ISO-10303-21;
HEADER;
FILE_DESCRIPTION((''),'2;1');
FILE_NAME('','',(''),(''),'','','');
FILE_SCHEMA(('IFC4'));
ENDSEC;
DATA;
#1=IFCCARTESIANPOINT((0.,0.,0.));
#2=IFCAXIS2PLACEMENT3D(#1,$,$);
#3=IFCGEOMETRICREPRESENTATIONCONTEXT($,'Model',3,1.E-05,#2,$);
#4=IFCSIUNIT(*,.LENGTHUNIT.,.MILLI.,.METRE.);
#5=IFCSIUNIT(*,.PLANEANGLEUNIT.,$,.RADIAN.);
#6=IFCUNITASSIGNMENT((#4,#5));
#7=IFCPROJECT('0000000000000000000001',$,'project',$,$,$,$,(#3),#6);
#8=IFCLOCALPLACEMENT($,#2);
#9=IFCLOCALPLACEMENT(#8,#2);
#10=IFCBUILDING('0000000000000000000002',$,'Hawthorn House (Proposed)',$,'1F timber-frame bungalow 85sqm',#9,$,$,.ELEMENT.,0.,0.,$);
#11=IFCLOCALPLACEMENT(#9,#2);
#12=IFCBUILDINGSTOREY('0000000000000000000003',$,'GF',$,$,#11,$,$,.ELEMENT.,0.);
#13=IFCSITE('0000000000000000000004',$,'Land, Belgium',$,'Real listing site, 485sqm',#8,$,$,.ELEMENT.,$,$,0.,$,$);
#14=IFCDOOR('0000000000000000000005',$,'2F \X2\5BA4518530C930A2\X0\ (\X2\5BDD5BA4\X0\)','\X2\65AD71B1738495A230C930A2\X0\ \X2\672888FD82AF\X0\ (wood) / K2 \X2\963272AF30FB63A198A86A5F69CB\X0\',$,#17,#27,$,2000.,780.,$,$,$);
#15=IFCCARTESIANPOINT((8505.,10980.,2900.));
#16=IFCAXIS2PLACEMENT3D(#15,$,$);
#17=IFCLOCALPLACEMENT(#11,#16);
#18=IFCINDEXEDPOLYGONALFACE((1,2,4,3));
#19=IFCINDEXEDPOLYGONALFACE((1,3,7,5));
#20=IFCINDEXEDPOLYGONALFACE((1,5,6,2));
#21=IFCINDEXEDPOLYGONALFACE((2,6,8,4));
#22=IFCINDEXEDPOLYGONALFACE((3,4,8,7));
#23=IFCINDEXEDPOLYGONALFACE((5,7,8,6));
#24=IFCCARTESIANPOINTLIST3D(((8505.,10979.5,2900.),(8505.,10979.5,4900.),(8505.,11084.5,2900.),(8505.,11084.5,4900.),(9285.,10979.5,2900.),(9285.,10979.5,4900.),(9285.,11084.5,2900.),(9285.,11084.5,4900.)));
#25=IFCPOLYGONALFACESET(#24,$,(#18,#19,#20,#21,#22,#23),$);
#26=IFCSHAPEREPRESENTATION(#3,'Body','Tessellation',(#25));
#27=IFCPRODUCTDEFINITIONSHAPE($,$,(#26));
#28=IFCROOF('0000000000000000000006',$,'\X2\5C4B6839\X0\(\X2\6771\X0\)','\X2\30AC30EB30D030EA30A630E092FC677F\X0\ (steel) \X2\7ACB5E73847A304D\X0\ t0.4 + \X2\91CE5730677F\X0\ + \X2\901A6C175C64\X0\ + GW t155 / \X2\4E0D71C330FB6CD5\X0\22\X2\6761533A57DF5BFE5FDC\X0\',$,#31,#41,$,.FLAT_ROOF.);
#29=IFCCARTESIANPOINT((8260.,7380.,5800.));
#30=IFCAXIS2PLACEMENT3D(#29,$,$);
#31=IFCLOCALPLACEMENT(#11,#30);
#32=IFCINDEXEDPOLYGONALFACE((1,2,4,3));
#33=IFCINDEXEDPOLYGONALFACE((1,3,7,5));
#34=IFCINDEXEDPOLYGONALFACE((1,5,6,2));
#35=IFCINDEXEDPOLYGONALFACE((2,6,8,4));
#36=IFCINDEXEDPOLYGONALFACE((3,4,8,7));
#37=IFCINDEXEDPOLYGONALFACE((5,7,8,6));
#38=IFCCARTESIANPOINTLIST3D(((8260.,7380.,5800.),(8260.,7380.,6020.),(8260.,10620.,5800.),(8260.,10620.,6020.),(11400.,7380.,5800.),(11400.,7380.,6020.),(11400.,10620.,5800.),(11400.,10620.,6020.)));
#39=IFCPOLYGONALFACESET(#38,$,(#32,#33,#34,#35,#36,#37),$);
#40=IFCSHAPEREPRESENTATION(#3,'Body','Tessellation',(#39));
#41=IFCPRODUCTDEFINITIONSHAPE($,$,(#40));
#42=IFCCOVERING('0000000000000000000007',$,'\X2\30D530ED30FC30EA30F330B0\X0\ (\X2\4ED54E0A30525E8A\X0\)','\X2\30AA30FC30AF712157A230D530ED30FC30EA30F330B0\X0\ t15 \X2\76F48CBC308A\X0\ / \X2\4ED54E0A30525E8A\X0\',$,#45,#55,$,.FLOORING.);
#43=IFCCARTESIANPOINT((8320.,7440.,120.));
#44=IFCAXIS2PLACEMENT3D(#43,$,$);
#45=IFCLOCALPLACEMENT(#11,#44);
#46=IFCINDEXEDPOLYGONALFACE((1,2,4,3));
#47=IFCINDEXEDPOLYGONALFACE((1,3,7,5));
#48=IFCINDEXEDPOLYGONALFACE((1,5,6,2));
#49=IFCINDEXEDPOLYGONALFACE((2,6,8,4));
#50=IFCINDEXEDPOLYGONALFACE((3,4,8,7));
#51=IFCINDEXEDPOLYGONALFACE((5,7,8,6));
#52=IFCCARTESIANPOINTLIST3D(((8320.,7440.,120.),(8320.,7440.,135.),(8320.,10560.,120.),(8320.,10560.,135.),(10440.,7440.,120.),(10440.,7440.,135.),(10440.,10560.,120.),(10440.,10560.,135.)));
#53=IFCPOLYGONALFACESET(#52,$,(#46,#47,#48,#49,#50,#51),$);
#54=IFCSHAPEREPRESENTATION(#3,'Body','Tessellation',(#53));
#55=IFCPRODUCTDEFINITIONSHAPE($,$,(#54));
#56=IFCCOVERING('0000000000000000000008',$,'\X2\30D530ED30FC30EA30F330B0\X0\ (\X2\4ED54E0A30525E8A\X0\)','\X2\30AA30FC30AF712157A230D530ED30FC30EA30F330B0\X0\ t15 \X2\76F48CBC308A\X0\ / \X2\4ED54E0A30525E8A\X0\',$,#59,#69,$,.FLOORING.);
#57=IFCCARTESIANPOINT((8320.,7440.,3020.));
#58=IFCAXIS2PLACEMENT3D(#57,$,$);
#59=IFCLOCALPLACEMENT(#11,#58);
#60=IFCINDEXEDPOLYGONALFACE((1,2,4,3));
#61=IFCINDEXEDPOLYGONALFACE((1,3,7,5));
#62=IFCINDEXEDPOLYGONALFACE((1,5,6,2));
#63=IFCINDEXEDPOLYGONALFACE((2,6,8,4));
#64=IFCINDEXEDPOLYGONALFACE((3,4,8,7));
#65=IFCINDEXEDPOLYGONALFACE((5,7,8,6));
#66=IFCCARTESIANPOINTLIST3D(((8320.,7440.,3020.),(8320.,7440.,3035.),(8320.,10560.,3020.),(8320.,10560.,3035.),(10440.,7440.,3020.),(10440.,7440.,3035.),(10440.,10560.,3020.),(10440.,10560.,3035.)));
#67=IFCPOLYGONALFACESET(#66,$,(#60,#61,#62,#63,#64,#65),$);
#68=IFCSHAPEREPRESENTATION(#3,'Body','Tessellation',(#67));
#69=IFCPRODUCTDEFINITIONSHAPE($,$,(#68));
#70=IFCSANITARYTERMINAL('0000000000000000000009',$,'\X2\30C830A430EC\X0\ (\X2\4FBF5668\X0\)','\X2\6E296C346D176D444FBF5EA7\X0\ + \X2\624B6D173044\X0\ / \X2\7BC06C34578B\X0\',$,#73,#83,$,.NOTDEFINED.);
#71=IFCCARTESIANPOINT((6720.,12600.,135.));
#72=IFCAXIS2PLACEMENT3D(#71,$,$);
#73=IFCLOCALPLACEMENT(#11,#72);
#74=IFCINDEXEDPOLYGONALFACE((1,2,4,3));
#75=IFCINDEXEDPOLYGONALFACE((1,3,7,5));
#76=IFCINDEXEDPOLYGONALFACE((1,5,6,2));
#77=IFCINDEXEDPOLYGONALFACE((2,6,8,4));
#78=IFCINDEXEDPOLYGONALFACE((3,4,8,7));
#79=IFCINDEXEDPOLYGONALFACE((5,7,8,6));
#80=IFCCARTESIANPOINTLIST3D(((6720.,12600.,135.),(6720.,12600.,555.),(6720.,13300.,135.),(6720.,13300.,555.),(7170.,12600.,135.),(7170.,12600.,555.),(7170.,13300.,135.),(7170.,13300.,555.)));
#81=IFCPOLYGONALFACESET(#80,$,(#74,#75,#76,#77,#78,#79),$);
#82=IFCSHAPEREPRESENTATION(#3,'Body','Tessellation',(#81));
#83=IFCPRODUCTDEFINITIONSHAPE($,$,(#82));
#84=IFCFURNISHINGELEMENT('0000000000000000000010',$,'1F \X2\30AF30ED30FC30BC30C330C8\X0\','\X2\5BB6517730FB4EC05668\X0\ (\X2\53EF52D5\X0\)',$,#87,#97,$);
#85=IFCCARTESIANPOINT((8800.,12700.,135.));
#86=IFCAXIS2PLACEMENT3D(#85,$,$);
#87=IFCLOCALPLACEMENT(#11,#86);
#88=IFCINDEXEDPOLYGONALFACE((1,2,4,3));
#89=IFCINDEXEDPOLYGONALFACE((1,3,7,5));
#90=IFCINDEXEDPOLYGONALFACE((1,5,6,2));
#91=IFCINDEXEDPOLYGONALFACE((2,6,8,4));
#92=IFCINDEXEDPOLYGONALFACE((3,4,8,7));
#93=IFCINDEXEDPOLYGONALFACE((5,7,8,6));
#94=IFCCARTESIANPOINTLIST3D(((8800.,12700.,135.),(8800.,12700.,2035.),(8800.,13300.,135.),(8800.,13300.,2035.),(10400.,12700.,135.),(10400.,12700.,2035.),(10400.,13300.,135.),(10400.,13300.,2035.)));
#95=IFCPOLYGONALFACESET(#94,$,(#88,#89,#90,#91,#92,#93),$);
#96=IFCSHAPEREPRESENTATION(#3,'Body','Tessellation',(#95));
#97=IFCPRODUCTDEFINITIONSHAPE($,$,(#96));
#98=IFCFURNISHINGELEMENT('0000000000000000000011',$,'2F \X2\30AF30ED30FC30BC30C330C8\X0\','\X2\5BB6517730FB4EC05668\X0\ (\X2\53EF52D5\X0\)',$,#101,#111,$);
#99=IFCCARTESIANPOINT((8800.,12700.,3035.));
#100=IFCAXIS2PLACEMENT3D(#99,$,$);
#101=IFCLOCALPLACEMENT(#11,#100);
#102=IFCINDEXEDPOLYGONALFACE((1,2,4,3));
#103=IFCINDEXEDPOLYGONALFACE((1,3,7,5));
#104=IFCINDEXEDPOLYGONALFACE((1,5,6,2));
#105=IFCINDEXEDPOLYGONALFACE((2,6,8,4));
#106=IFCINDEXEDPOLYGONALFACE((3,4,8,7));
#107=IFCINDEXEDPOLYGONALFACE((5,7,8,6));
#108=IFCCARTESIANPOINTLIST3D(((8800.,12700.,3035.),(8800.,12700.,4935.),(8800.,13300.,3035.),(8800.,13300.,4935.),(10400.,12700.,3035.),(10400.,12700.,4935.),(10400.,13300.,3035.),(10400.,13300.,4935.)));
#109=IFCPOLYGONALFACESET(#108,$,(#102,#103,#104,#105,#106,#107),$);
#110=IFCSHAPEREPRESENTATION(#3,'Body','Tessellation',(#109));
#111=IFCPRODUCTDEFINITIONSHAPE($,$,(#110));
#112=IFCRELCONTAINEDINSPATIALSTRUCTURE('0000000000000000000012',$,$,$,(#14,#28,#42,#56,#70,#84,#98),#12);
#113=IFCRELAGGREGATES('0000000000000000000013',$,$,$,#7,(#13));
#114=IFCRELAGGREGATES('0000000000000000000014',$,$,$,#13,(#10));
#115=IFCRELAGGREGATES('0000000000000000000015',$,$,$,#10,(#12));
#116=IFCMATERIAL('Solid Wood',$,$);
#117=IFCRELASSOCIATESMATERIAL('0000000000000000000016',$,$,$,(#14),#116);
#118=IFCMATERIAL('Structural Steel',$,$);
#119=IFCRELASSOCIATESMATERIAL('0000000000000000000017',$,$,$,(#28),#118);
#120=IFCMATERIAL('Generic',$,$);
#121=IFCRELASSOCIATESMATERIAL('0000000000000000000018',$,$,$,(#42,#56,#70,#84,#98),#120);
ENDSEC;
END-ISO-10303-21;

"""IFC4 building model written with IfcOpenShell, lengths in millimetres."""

from ifc_helpers import new_model, si_unit, frame, frame_2d, origin, place, context, project, spatial, rectangle, extrude, material, element, save


model = new_model("IFC4")

# Units and contexts
model_context = context("Model", 3, precision=1e-05, world=origin())
ifc_project = project(units=[si_unit("LENGTHUNIT", "METRE", prefix="MILLI"), si_unit("PLANEANGLEUNIT", "RADIAN")], contexts=[model_context])

# Site, building, storey
site_placement = place(None, origin())
site = spatial("IfcSite", under=ifc_project, at=site_placement, Name="Land, Belgium", ObjectType="Real listing site, 485sqm", CompositionType="ELEMENT", RefElevation=0.0)
building_placement = place(site_placement, origin())
building = spatial("IfcBuilding", under=site, at=building_placement, Name="Hawthorn House (Proposed)", ObjectType="1F timber-frame bungalow 85sqm", CompositionType="ELEMENT", ElevationOfRefHeight=0.0, ElevationOfTerrain=0.0)
storey_placement = place(building_placement, origin())
storey = spatial("IfcBuildingStorey", under=building, at=storey_placement, Name="GF", CompositionType="ELEMENT", Elevation=0.0)

# Shared definitions
ifc_material_1 = material(Name="Solid Wood")

# Door
door_1_placement = place(storey_placement, frame((8505.0, 10980.0, 2900.0)))
element("IfcDoor", 1, at=door_1_placement, inside=storey, material=ifc_material_1, Name="2F 室内ドア (寝室)", Description="断熱玄関ドア 木製芯 (wood) / K2 防犯・採風機構", OverallHeight=2000.0, OverallWidth=780.0, context=model_context, shape_type="SweptSolid", body=[
    extrude(rectangle(XDim=780.0, YDim=105.0, at=frame_2d((390.0, 52.0))), frame((8505.0, 10980.0, 2900.0)), (0.0, 0.0, 1.0), 2000.0),
])

# Roof
ifc_material_2 = material(Name="Structural Steel")
roof_placement = place(storey_placement, frame((8260.0, 7380.0, 5800.0)))
element("IfcRoof", 2, at=roof_placement, inside=storey, material=ifc_material_2, Name="屋根(東)", Description="ガルバリウム鋼板 (steel) 立平葺き t0.4 + 野地板 + 通気層 + GW t155 / 不燃・法22条区域対応", PredefinedType="FLAT_ROOF", context=model_context, shape_type="SweptSolid", body=[
    extrude(rectangle(XDim=3140.0, YDim=3240.0, at=frame_2d((1570.0, 1620.0))), frame((8260.0, 7380.0, 5800.0)), (0.0, 0.0, 1.0), 220.0),
])

# Coverings
ifc_material_3 = material(Name="Generic")
covering_1_placement = place(storey_placement, frame((8320.0, 7440.0, 120.0)))
element("IfcCovering", 3, at=covering_1_placement, inside=storey, material=ifc_material_3, Name="フローリング (仕上げ床)", Description="オーク無垢フローリング t15 直貼り / 仕上げ床", PredefinedType="FLOORING", context=model_context, shape_type="SweptSolid", body=[
    extrude(rectangle(XDim=2120.0, YDim=3120.0, at=frame_2d((1060.0, 1560.0))), frame((8320.0, 7440.0, 120.0)), (0.0, 0.0, 1.0), 15.0),
])
covering_2_placement = place(storey_placement, frame((8320.0, 7440.0, 3020.0)))
element("IfcCovering", 4, at=covering_2_placement, inside=storey, material=ifc_material_3, Name="フローリング (仕上げ床)", Description="オーク無垢フローリング t15 直貼り / 仕上げ床", PredefinedType="FLOORING", context=model_context, shape_type="SweptSolid", body=[
    extrude(rectangle(XDim=2120.0, YDim=3120.0, at=frame_2d((1060.0, 1560.0))), frame((8320.0, 7440.0, 3020.0)), (0.0, 0.0, 1.0), 15.0),
])

# Sanitary terminal
sanitary_terminal_placement = place(storey_placement, frame((6720.0, 12600.0, 135.0)))
element("IfcSanitaryTerminal", 5, at=sanitary_terminal_placement, inside=storey, material=ifc_material_3, Name="トイレ (便器)", Description="温水洗浄便座 + 手洗い / 節水型", PredefinedType="NOTDEFINED", context=model_context, shape_type="SweptSolid", body=[
    extrude(rectangle(XDim=450.0, YDim=700.0, at=frame_2d((225.0, 350.0))), frame((6720.0, 12600.0, 135.0)), (0.0, 0.0, 1.0), 420.0),
])

# Furnishing elements
furnishing_1_placement = place(storey_placement, frame((8800.0, 12700.0, 135.0)))
element("IfcFurnishingElement", 6, at=furnishing_1_placement, inside=storey, material=ifc_material_3, Name="1F クローゼット", Description="家具・什器 (可動)", context=model_context, shape_type="SweptSolid", body=[
    extrude(rectangle(XDim=1600.0, YDim=600.0, at=frame_2d((800.0, 300.0))), frame((8800.0, 12700.0, 135.0)), (0.0, 0.0, 1.0), 1900.0),
])
furnishing_2_placement = place(storey_placement, frame((8800.0, 12700.0, 3035.0)))
element("IfcFurnishingElement", 7, at=furnishing_2_placement, inside=storey, material=ifc_material_3, Name="2F クローゼット", Description="家具・什器 (可動)", context=model_context, shape_type="SweptSolid", body=[
    extrude(rectangle(XDim=1600.0, YDim=600.0, at=frame_2d((800.0, 300.0))), frame((8800.0, 12700.0, 3035.0)), (0.0, 0.0, 1.0), 1900.0),
])

save(model, "model.ifc")
